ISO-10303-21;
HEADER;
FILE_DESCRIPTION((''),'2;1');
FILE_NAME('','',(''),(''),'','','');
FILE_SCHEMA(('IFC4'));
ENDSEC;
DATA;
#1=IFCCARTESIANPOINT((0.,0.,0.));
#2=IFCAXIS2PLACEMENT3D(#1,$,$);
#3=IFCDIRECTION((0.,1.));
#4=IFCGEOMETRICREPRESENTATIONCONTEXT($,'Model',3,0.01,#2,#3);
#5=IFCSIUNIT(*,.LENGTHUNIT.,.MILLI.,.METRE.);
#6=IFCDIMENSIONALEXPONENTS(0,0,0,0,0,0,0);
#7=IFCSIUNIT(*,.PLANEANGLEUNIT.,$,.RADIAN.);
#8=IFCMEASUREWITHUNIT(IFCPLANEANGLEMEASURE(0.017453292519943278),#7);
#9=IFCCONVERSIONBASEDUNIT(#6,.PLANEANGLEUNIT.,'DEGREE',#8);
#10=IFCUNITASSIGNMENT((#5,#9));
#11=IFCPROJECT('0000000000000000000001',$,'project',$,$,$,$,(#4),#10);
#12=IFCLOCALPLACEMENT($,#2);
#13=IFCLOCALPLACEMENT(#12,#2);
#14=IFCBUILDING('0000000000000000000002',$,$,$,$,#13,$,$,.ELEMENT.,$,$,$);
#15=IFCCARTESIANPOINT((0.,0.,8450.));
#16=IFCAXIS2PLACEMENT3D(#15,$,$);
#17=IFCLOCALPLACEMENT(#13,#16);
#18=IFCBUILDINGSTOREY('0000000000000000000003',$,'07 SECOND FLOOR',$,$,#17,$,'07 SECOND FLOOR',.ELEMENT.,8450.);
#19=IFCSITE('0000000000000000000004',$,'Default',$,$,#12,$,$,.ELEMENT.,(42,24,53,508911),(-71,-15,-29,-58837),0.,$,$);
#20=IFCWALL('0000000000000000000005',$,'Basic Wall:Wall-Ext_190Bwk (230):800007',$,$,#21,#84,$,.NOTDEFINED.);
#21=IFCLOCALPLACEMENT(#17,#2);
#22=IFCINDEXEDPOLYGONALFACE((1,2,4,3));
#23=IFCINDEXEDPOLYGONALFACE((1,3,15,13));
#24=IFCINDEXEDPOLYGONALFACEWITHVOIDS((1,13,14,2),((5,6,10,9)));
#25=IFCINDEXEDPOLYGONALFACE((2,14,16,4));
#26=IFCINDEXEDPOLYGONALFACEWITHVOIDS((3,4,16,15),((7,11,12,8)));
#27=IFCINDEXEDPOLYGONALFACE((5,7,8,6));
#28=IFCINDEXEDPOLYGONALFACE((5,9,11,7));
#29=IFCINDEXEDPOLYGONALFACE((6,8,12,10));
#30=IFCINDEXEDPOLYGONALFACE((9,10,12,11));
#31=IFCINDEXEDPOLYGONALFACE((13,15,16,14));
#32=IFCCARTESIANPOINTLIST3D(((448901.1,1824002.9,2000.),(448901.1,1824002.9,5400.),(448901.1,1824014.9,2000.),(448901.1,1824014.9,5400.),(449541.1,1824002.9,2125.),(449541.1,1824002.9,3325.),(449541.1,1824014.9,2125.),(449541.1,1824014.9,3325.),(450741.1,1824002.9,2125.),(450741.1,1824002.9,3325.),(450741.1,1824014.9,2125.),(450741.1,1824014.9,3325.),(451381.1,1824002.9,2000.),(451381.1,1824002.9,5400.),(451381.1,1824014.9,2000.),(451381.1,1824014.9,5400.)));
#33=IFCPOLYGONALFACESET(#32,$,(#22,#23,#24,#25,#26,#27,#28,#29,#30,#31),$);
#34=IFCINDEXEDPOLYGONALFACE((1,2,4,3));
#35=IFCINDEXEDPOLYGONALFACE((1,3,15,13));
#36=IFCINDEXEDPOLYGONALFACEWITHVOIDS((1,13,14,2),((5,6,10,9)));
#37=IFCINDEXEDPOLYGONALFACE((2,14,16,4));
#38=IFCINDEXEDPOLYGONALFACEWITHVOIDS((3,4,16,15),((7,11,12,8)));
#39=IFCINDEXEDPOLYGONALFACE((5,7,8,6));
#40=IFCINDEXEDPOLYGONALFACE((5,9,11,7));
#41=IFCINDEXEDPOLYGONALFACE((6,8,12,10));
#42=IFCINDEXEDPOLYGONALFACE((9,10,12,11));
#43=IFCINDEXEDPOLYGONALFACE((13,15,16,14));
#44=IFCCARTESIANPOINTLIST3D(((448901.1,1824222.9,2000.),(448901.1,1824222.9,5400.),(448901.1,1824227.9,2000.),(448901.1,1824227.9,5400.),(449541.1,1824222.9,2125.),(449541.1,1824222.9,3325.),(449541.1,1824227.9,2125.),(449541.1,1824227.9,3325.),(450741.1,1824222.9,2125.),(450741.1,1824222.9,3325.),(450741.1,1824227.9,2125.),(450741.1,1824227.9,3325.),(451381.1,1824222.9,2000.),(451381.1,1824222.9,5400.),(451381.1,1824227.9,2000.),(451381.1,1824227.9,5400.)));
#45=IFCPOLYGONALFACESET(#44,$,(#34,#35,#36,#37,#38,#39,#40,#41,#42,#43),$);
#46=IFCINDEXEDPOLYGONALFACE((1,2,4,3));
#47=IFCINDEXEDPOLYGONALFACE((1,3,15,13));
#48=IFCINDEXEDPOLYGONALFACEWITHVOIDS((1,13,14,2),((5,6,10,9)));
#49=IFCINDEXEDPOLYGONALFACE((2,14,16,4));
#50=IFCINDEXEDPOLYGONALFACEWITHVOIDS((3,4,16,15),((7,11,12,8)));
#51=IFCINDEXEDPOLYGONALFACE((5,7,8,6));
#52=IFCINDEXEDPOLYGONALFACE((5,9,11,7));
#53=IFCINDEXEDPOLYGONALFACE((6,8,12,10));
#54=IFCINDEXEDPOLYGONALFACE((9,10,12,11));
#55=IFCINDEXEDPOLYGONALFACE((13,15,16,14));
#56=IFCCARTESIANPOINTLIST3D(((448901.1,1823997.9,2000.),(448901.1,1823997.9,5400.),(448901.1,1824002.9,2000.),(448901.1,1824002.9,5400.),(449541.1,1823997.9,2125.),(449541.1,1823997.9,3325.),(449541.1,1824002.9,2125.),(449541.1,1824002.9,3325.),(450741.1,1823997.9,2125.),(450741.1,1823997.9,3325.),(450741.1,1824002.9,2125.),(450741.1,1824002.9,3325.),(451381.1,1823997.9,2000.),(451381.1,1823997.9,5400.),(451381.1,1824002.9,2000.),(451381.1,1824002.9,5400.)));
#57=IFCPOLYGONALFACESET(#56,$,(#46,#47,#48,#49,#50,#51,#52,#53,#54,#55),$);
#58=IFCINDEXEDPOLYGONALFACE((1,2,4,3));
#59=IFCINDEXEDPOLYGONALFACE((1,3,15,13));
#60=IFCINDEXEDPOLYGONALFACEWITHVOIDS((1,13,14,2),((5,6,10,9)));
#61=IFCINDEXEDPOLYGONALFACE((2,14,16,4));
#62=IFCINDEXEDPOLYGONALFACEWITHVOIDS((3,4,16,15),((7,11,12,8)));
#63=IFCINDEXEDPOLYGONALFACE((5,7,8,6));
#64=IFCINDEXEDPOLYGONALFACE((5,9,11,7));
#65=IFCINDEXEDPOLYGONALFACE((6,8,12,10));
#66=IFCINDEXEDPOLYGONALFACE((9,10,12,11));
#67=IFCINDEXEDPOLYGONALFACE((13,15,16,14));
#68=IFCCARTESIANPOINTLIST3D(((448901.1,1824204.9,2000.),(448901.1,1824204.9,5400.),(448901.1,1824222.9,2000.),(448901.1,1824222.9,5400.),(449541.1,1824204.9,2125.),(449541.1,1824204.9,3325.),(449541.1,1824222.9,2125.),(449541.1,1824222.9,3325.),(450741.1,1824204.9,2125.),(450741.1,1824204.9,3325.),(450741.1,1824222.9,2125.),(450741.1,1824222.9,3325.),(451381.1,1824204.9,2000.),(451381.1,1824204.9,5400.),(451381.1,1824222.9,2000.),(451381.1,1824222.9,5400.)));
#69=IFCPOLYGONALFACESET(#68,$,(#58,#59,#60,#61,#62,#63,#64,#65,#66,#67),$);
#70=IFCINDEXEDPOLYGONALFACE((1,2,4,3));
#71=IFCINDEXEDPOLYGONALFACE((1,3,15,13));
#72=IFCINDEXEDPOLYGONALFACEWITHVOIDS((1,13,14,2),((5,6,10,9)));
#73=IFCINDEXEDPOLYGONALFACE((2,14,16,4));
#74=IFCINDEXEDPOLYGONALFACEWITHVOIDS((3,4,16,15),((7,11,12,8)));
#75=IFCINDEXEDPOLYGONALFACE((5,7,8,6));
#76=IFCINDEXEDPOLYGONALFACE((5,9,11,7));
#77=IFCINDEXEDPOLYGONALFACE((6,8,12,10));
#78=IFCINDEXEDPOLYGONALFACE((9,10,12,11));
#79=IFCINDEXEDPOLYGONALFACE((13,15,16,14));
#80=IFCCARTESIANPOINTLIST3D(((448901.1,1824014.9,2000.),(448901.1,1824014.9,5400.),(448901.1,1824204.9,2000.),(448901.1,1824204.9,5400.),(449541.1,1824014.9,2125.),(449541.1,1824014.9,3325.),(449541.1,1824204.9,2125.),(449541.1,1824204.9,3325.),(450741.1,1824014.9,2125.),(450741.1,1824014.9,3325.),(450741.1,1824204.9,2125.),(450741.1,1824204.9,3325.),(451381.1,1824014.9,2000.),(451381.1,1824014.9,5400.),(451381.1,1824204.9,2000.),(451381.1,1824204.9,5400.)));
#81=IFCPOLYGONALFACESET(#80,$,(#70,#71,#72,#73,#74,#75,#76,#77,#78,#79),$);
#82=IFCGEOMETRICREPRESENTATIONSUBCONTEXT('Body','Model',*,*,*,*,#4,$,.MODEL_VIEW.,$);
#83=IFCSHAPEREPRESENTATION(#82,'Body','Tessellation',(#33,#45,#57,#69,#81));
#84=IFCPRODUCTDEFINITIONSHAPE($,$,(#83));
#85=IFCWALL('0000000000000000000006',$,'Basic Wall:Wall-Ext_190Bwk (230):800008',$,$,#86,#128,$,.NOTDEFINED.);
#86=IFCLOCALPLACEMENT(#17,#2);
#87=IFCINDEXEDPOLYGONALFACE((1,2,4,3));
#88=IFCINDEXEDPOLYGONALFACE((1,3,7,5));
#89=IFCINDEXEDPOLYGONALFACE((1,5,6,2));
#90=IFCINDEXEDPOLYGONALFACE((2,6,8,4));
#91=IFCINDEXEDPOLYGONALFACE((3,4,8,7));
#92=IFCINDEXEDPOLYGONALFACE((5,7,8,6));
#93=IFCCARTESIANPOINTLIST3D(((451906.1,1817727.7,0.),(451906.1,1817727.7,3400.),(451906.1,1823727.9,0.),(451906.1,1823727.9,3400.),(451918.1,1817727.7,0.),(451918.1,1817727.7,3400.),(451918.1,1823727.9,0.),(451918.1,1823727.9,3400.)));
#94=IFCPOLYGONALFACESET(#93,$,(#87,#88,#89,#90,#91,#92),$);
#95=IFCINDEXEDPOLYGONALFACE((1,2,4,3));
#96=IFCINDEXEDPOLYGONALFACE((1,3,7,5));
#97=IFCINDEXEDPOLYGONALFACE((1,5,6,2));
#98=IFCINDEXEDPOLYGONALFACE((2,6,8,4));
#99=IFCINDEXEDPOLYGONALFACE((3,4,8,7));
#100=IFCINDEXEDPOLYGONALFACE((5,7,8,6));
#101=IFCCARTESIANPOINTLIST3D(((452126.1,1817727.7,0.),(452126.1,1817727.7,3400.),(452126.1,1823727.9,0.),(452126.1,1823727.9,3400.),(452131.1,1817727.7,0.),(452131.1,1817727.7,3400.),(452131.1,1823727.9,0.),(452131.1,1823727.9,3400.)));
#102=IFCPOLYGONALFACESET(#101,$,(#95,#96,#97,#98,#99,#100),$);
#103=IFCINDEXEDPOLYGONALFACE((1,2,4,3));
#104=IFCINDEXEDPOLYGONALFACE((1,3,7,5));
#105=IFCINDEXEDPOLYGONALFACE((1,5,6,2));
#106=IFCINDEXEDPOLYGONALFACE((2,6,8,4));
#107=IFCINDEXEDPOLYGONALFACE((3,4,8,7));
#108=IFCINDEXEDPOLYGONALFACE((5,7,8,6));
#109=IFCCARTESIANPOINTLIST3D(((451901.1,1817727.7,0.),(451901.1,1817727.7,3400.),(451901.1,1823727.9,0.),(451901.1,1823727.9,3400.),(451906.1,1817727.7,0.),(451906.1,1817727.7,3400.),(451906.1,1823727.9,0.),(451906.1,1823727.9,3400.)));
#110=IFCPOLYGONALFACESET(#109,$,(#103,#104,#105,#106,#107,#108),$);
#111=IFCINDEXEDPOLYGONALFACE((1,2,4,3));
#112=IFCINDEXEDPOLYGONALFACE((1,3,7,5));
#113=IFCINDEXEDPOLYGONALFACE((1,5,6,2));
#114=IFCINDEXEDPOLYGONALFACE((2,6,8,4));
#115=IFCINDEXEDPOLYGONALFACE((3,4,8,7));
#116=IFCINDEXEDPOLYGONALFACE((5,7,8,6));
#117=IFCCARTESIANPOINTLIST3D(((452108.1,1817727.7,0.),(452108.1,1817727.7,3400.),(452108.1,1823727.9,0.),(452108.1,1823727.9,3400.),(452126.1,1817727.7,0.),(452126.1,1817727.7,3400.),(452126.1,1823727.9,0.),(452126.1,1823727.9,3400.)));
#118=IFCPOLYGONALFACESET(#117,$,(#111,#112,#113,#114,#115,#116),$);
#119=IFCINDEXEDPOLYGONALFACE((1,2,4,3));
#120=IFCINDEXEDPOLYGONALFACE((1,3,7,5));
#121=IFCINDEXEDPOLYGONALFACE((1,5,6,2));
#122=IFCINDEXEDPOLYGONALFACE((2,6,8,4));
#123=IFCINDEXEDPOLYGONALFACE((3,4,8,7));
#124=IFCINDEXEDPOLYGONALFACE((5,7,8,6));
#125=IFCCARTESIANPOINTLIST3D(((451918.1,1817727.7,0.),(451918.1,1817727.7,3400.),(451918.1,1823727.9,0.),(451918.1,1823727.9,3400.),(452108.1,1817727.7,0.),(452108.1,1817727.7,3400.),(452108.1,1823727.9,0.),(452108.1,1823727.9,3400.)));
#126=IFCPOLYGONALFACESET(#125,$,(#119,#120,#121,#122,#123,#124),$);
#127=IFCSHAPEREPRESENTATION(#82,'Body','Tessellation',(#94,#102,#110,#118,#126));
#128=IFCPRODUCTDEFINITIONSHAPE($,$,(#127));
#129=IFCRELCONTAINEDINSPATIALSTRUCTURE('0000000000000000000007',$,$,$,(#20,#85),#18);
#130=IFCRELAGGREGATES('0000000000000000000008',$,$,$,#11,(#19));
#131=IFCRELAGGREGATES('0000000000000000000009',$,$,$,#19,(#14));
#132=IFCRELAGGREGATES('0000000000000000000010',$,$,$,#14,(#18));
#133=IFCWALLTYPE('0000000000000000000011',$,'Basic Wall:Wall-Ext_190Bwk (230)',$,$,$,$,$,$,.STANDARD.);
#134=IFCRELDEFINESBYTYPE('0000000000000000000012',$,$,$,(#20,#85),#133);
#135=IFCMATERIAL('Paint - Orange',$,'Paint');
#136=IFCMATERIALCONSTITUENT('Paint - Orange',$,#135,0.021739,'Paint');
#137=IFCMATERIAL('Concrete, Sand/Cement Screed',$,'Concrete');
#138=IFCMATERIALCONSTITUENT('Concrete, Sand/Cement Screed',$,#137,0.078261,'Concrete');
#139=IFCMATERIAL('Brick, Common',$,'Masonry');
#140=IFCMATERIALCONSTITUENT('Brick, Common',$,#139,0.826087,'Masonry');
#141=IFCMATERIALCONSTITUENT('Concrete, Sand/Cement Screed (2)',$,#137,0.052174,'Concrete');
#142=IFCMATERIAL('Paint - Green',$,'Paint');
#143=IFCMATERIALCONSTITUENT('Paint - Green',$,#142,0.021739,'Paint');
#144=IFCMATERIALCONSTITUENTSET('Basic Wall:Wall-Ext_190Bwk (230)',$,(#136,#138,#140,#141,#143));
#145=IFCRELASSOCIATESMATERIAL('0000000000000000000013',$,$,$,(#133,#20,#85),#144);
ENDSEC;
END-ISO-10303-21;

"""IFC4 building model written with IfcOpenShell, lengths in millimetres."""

from ifc_helpers import new_model, entity, si_unit, converted_unit, direction, frame, origin, place, context, subcontext, project, spatial, indexed_curve, outline, extrude, material, constituent, constituent_set, type_object, element, save


model = new_model("IFC4")

# Units and contexts
model_context = context("Model", 3, precision=0.01, world=origin(), true_north=direction((0.0, 1.0)))
body_context = subcontext(model_context, "Body", "Model", "MODEL_VIEW")
ifc_project = project(units=[si_unit("LENGTHUNIT", "METRE", prefix="MILLI"), converted_unit("PLANEANGLEUNIT", "DEGREE", entity("IfcPlaneAngleMeasure", 0.017453292519943278), si_unit("PLANEANGLEUNIT", "RADIAN"), dimensions=[0, 0, 0, 0, 0, 0, 0])], contexts=[model_context])

# Site, building, storey
site_placement = place(None, origin())
site = spatial("IfcSite", under=ifc_project, at=site_placement, Name="Default", CompositionType="ELEMENT", RefLatitude=(42, 24, 53, 508911), RefLongitude=(-71, -15, -29, -58837), RefElevation=0.0)
building_placement = place(site_placement, origin())
building = spatial("IfcBuilding", under=site, at=building_placement, CompositionType="ELEMENT")
storey_placement = place(building_placement, frame((0.0, 0.0, 8450.0)))
storey = spatial("IfcBuildingStorey", under=building, at=storey_placement, Name="07 SECOND FLOOR", LongName="07 SECOND FLOOR", CompositionType="ELEMENT", Elevation=8450.0)

# Shared definitions
ifc_material_1 = material(Name="Concrete, Sand/Cement Screed", Category="Concrete")
ifc_material_2 = material(Name="Brick, Common", Category="Masonry")

# Wall, opening
ifc_material_3 = material(Name="Paint - Orange", Category="Paint")
ifc_constituent_1 = constituent(ifc_material_3, Name="Paint - Orange", Category="Paint", fraction=0.021739)
ifc_constituent_2 = constituent(ifc_material_1, Name="Concrete, Sand/Cement Screed", Category="Concrete", fraction=0.078261)
ifc_constituent_3 = constituent(ifc_material_2, Name="Brick, Common", Category="Masonry", fraction=0.826087)
ifc_constituent_4 = constituent(ifc_material_1, Name="Concrete, Sand/Cement Screed (2)", Category="Concrete", fraction=0.052174)
ifc_material_4 = material(Name="Paint - Green", Category="Paint")
ifc_constituent_5 = constituent(ifc_material_4, Name="Paint - Green", Category="Paint", fraction=0.021739)
ifc_constituent_set_1 = constituent_set(constituents=[ifc_constituent_1, ifc_constituent_2, ifc_constituent_3, ifc_constituent_4, ifc_constituent_5], Name="Basic Wall:Wall-Ext_190Bwk (230)")
wall_type_1 = type_object("IfcWallType", Name="Basic Wall:Wall-Ext_190Bwk (230)", PredefinedType="STANDARD", material=ifc_constituent_set_1)
wall_1_placement = place(storey_placement, frame((448901.1, 1824112.9, 2000.0)))
wall_1 = element("IfcWall", 1, at=wall_1_placement, inside=storey, type_object=wall_type_1, material=ifc_constituent_set_1, Name="Basic Wall:Wall-Ext_190Bwk (230):800007", PredefinedType="NOTDEFINED", context=body_context, shape_type="SweptSolid", body=[
    extrude(outline(indexed_curve([(-1700.0, -1240.0), (1700.0, -1240.0), (1700.0, 1240.0), (-1700.0, 1240.0), (-1700.0, -1240.0)], self_intersect=False), holes=[indexed_curve([(-1575.0, -600.0), (-1575.0, 600.0), (-375.0, 600.0), (-375.0, -600.0), (-1575.0, -600.0)], self_intersect=False)]), frame((1240.0, -110.0, 1700.0), z_axis=(0.0, 1.0, 0.0), x_axis=(0.0, 0.0, 1.0)), (0.0, 0.0, 1.0), 12.0),
    extrude(outline(indexed_curve([(-1700.0, -1240.0), (1700.0, -1240.0), (1700.0, 1240.0), (-1700.0, 1240.0), (-1700.0, -1240.0)], self_intersect=False), holes=[indexed_curve([(-1575.0, -600.0), (-1575.0, 600.0), (-375.0, 600.0), (-375.0, -600.0), (-1575.0, -600.0)], self_intersect=False)]), frame((1240.0, 110.0, 1700.0), z_axis=(0.0, 1.0, 0.0), x_axis=(0.0, 0.0, 1.0)), (0.0, 0.0, 1.0), 5.0),
    extrude(outline(indexed_curve([(-1700.0, -1240.0), (1700.0, -1240.0), (1700.0, 1240.0), (-1700.0, 1240.0), (-1700.0, -1240.0)], self_intersect=False), holes=[indexed_curve([(-375.0, -600.0), (-1575.0, -600.0), (-1575.0, 600.0), (-375.0, 600.0), (-375.0, -600.0)], self_intersect=False)]), frame((1240.0, -115.0, 1700.0), z_axis=(0.0, 1.0, 0.0), x_axis=(0.0, 0.0, 1.0)), (0.0, 0.0, 1.0), 5.0),
    extrude(outline(indexed_curve([(-1700.0, -1240.0), (1700.0, -1240.0), (1700.0, 1240.0), (-1700.0, 1240.0), (-1700.0, -1240.0)], self_intersect=False), holes=[indexed_curve([(-1575.0, -600.0), (-1575.0, 600.0), (-375.0, 600.0), (-375.0, -600.0), (-1575.0, -600.0)], self_intersect=False)]), frame((1240.0, 92.0, 1700.0), z_axis=(0.0, 1.0, 0.0), x_axis=(0.0, 0.0, 1.0)), (0.0, 0.0, 1.0), 18.0),
    extrude(outline(indexed_curve([(-1700.0, -1240.0), (1700.0, -1240.0), (1700.0, 1240.0), (-1700.0, 1240.0), (-1700.0, -1240.0)], self_intersect=False), holes=[indexed_curve([(-1575.0, -600.0), (-1575.0, 600.0), (-375.0, 600.0), (-375.0, -600.0), (-1575.0, -600.0)], self_intersect=False)]), frame((1240.0, -98.0, 1700.0), z_axis=(0.0, 1.0, 0.0), x_axis=(0.0, 0.0, 1.0)), (0.0, 0.0, 1.0), 190.0),
])
opening_1_placement = place(wall_1_placement, frame((1840.0, 115.0, 125.0)))
element("IfcOpeningElement", 2, at=opening_1_placement, cuts=wall_1, PredefinedType="OPENING", context=body_context, shape_type="SweptSolid", body=[
    extrude(outline(indexed_curve([(1200.0, 1200.0), (0.0, 1200.0), (0.0, 0.0), (1200.0, 0.0), (1200.0, 1200.0)], self_intersect=False)), frame((0.0, 0.0, 0.0), z_axis=(0.0, -1.0, 0.0), x_axis=(0.0, 0.0, 1.0)), (0.0, 0.0, 1.0), 230.0),
])

# Wall
wall_2_placement = place(storey_placement, frame((452016.1, 1823727.9, 0.0), z_axis=(0.0, 0.0, 1.0), x_axis=(0.0, -1.0, 0.0)))
element("IfcWall", 3, at=wall_2_placement, inside=storey, type_object=wall_type_1, material=ifc_constituent_set_1, Name="Basic Wall:Wall-Ext_190Bwk (230):800008", PredefinedType="NOTDEFINED", context=body_context, shape_type="SweptSolid", body=[
    extrude(outline(indexed_curve([(-3000.1, -6.0), (3000.1, -6.0), (3000.1, 6.0), (-3000.1, 6.0), (-3000.1, -6.0)], self_intersect=False)), frame((3000.1, -104.0, 0.0)), (0.0, 0.0, 1.0), 3400.0),
    extrude(outline(indexed_curve([(-2.5, -3000.1), (2.5, -3000.1), (2.5, 3000.1), (-2.5, 3000.1), (-2.5, -3000.1)], self_intersect=False)), frame((3000.1, 112.5, 0.0), z_axis=(0.0, 0.0, 1.0), x_axis=(0.0, -1.0, 0.0)), (0.0, 0.0, 1.0), 3400.0),
    extrude(outline(indexed_curve([(-2.5, -3000.1), (2.5, -3000.1), (2.5, 3000.1), (-2.5, 3000.1), (-2.5, -3000.1)], self_intersect=False)), frame((3000.1, -112.5, 0.0), z_axis=(0.0, 0.0, 1.0), x_axis=(0.0, 1.0, 0.0)), (0.0, 0.0, 1.0), 3400.0),
    extrude(outline(indexed_curve([(-3000.1, -9.0), (3000.1, -9.0), (3000.1, 9.0), (-3000.1, 9.0), (-3000.1, -9.0)], self_intersect=False)), frame((3000.1, 101.0, 0.0)), (0.0, 0.0, 1.0), 3400.0),
    extrude(outline(indexed_curve([(-3000.1, -95.0), (3000.1, -95.0), (3000.1, 95.0), (-3000.1, 95.0), (-3000.1, -95.0)], self_intersect=False)), frame((3000.1, -3.0, 0.0)), (0.0, 0.0, 1.0), 3400.0),
])

save(model, "model.ifc")
